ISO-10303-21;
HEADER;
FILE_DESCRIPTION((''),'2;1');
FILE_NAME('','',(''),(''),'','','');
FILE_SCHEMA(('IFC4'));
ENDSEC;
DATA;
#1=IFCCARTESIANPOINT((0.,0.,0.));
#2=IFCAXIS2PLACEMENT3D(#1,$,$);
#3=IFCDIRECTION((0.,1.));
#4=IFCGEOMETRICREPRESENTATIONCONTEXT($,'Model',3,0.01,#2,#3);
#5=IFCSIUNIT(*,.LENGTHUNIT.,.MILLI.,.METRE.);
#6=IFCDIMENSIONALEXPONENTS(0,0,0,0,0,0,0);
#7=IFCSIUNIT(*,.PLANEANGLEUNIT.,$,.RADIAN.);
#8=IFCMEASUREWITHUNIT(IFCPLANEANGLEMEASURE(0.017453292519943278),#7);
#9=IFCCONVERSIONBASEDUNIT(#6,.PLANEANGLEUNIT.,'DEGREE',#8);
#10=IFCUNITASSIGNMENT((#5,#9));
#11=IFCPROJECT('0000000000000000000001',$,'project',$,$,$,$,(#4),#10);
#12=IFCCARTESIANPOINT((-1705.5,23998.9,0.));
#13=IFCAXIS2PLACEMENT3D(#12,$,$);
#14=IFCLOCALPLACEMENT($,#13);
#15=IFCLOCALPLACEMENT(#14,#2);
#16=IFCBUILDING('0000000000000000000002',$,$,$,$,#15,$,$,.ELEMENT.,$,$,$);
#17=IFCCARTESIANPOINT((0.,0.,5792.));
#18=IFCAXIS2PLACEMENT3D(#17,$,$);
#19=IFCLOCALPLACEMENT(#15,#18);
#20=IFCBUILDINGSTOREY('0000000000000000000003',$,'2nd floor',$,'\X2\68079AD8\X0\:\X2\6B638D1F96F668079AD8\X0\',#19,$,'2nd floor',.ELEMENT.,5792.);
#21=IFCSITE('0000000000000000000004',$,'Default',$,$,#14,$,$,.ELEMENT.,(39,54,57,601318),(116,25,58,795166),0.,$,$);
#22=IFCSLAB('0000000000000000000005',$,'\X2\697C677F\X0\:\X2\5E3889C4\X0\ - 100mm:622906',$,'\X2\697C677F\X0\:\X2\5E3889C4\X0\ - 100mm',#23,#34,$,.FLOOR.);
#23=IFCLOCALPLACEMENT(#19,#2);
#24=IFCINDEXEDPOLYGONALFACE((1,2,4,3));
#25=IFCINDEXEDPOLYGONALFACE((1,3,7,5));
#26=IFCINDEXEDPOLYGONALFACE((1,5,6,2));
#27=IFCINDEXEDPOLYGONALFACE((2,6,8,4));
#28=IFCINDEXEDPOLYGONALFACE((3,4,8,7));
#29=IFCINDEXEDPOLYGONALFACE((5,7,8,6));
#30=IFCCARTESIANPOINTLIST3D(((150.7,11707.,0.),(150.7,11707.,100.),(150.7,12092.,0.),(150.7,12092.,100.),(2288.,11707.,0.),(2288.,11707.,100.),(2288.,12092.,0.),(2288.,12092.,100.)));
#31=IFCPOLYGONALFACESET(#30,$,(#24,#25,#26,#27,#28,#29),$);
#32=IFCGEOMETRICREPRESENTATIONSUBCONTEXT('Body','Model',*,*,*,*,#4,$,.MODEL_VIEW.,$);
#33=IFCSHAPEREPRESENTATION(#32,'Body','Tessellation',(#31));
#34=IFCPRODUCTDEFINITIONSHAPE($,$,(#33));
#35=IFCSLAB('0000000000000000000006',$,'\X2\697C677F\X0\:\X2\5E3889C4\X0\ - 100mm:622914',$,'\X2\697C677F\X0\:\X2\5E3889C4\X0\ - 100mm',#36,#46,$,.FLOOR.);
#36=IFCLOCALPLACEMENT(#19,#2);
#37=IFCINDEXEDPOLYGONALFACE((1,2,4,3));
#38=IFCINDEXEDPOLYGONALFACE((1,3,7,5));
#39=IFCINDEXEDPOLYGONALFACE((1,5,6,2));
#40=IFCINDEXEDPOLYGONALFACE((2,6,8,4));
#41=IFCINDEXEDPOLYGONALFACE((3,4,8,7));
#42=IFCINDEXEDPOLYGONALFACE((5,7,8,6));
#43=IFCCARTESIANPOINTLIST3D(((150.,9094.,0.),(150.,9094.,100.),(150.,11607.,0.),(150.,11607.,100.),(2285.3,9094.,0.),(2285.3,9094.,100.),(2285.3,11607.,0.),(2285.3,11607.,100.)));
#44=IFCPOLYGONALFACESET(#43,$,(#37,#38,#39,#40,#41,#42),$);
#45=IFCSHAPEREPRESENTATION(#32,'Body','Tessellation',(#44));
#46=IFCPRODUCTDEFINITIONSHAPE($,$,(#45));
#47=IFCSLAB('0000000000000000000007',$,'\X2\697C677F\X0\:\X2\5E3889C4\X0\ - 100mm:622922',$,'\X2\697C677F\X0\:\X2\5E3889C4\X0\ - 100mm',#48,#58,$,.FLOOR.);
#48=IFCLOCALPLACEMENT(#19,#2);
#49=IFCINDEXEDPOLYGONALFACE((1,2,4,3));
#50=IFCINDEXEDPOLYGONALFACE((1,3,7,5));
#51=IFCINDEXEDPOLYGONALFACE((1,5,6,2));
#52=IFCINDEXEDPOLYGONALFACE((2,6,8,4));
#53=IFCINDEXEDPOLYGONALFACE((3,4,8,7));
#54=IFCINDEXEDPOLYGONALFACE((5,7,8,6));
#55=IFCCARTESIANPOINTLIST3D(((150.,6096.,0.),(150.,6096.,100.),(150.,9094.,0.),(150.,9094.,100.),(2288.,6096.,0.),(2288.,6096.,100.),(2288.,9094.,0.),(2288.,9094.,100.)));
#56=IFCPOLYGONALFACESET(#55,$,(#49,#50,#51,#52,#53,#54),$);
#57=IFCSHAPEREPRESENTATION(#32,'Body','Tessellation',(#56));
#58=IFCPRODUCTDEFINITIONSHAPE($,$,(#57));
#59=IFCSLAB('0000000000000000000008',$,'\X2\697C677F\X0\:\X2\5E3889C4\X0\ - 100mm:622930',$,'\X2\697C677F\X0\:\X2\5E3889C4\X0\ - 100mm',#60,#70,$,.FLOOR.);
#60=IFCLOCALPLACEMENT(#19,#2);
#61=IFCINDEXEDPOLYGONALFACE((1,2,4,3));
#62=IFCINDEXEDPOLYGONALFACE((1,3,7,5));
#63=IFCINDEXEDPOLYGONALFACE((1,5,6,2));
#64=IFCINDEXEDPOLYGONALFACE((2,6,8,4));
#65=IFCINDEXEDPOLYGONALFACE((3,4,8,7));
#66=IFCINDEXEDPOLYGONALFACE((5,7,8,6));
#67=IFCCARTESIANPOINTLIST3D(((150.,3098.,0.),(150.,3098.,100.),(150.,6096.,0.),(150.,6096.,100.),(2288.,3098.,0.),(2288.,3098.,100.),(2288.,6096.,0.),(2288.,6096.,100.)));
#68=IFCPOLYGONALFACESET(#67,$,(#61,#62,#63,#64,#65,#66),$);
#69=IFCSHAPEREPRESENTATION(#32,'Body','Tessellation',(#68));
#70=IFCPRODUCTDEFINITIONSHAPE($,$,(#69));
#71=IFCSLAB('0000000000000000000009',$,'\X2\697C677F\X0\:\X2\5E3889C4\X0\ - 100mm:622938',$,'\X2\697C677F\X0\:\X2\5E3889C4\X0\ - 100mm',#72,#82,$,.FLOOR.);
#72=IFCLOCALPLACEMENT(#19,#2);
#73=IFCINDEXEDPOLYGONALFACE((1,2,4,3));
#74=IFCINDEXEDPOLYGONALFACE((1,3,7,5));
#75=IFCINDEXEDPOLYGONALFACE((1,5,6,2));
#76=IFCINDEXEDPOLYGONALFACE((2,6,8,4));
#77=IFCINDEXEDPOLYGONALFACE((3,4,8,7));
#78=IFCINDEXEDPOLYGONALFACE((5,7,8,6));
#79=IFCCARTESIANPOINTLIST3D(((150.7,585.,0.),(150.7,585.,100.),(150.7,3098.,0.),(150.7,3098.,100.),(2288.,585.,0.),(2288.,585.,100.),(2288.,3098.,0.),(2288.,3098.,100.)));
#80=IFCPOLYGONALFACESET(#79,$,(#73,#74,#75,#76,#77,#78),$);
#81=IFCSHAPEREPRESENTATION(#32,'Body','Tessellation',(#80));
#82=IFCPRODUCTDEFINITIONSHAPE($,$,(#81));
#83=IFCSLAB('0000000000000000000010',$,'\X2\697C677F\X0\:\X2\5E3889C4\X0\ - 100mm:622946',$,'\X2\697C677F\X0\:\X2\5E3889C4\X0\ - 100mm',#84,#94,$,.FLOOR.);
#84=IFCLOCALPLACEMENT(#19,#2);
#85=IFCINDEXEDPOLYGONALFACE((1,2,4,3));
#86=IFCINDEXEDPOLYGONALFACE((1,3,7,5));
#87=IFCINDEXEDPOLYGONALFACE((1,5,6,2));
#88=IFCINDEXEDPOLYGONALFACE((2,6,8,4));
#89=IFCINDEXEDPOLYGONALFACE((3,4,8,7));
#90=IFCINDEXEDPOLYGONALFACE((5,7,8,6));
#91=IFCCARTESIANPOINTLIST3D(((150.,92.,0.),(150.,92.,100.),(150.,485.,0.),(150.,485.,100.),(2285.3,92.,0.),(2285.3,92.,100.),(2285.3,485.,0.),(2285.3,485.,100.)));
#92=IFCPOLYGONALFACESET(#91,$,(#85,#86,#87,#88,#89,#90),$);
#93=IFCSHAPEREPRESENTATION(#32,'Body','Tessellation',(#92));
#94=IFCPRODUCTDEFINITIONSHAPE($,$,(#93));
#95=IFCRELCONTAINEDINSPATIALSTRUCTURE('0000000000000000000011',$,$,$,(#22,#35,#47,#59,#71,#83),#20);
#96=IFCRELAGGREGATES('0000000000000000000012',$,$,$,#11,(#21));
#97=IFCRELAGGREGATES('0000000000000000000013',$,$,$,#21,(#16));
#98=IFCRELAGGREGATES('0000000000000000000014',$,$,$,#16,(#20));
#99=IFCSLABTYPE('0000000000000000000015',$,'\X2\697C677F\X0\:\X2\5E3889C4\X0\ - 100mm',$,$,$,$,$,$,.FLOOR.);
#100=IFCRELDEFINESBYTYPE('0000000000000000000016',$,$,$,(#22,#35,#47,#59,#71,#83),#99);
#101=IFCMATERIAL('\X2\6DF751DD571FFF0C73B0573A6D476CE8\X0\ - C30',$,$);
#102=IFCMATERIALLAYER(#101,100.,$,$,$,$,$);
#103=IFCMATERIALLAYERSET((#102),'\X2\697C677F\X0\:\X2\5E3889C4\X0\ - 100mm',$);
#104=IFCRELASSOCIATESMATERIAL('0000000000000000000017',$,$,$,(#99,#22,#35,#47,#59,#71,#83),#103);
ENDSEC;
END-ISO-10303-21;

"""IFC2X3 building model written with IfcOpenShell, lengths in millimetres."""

from ifc_helpers import new_model, entity, si_unit, converted_unit, direction, frame, frame_2d, origin, origin_2d_with_axis, place, context, subcontext, project, spatial, rectangle, extrude, material, layer, layer_set, layer_usage, type_object, element, save


model = new_model("IFC2X3")

# Units and contexts
model_context = context("Model", 3, precision=0.01, world=origin(), true_north=direction((0.0, 1.0)))
body_context = subcontext(model_context, "Body", "Model", "MODEL_VIEW")
ifc_project = project(units=[si_unit("LENGTHUNIT", "METRE", prefix="MILLI"), converted_unit("PLANEANGLEUNIT", "DEGREE", entity("IfcPlaneAngleMeasure", 0.017453292519943278), si_unit("PLANEANGLEUNIT", "RADIAN"), dimensions=[0, 0, 0, 0, 0, 0, 0])], contexts=[model_context])

# Site, building, storey
site_placement = place(None, frame((-1705.5, 23998.9, 0.0)))
site = spatial("IfcSite", under=ifc_project, at=site_placement, Name="Default", CompositionType="ELEMENT", RefLatitude=(39, 54, 57, 601318), RefLongitude=(116, 25, 58, 795166), RefElevation=0.0)
building_placement = place(site_placement, origin())
building = spatial("IfcBuilding", under=site, at=building_placement, CompositionType="ELEMENT")
storey_placement = place(building_placement, frame((0.0, 0.0, 5792.0)))
storey = spatial("IfcBuildingStorey", under=building, at=storey_placement, Name="2nd floor", ObjectType="标高:正负零标高", LongName="2nd floor", CompositionType="ELEMENT", Elevation=5792.0)

# Slabs
ifc_material_1 = material(Name="混凝土，现场浇注 - C30")
ifc_layer_1 = layer(ifc_material_1, 100.0)
ifc_layer_set_1 = layer_set([ifc_layer_1], Name="楼板:常规 - 100mm")
ifc_layer_usage_1 = layer_usage(ifc_layer_set_1, "AXIS3", "POSITIVE", 0.0)
slab_type = type_object("IfcSlabType", Name="楼板:常规 - 100mm", PredefinedType="FLOOR", material=ifc_layer_set_1)
slab_1_placement = place(storey_placement, origin())
element("IfcSlab", 1, at=slab_1_placement, inside=storey, type_object=slab_type, material=ifc_layer_usage_1, Name="楼板:常规 - 100mm:622906", ObjectType="楼板:常规 - 100mm", PredefinedType="FLOOR", context=body_context, shape_type="SweptSolid", body=[
    extrude(rectangle(XDim=385.0, YDim=2137.3, at=origin_2d_with_axis()), frame((1219.3, 11899.5, 100.0), z_axis=(0.0, 0.0, -1.0), x_axis=(0.0, 1.0, 0.0)), (0.0, 0.0, 1.0), 100.0),
])
ifc_layer_usage_2 = layer_usage(ifc_layer_set_1, "AXIS3", "POSITIVE", 0.0)
slab_2_placement = place(storey_placement, origin())
element("IfcSlab", 2, at=slab_2_placement, inside=storey, type_object=slab_type, material=ifc_layer_usage_2, Name="楼板:常规 - 100mm:622914", ObjectType="楼板:常规 - 100mm", PredefinedType="FLOOR", context=body_context, shape_type="SweptSolid", body=[
    extrude(rectangle(XDim=2513.0, YDim=2135.3, at=frame_2d((0.0, 0.0), x_axis=(1.0, 0.0))), frame((1217.6, 10350.5, 100.0), z_axis=(0.0, 0.0, -1.0), x_axis=(0.0, 1.0, 0.0)), (0.0, 0.0, 1.0), 100.0),
])
ifc_layer_usage_3 = layer_usage(ifc_layer_set_1, "AXIS3", "POSITIVE", 0.0)
slab_3_placement = place(storey_placement, origin())
element("IfcSlab", 3, at=slab_3_placement, inside=storey, type_object=slab_type, material=ifc_layer_usage_3, Name="楼板:常规 - 100mm:622922", ObjectType="楼板:常规 - 100mm", PredefinedType="FLOOR", context=body_context, shape_type="SweptSolid", body=[
    extrude(rectangle(XDim=2998.0, YDim=2138.0, at=origin_2d_with_axis()), frame((1219.0, 7595.0, 100.0), z_axis=(0.0, 0.0, -1.0), x_axis=(0.0, 1.0, 0.0)), (0.0, 0.0, 1.0), 100.0),
])
ifc_layer_usage_4 = layer_usage(ifc_layer_set_1, "AXIS3", "POSITIVE", 0.0)
slab_4_placement = place(storey_placement, origin())
element("IfcSlab", 4, at=slab_4_placement, inside=storey, type_object=slab_type, material=ifc_layer_usage_4, Name="楼板:常规 - 100mm:622930", ObjectType="楼板:常规 - 100mm", PredefinedType="FLOOR", context=body_context, shape_type="SweptSolid", body=[
    extrude(rectangle(XDim=2998.0, YDim=2138.0, at=frame_2d((0.0, 0.0), x_axis=(1.0, 0.0))), frame((1219.0, 4597.0, 100.0), z_axis=(0.0, 0.0, -1.0), x_axis=(0.0, 1.0, 0.0)), (0.0, 0.0, 1.0), 100.0),
])
ifc_layer_usage_5 = layer_usage(ifc_layer_set_1, "AXIS3", "POSITIVE", 0.0)
slab_5_placement = place(storey_placement, origin())
element("IfcSlab", 5, at=slab_5_placement, inside=storey, type_object=slab_type, material=ifc_layer_usage_5, Name="楼板:常规 - 100mm:622938", ObjectType="楼板:常规 - 100mm", PredefinedType="FLOOR", context=body_context, shape_type="SweptSolid", body=[
    extrude(rectangle(XDim=2513.0, YDim=2137.3, at=origin_2d_with_axis()), frame((1219.3, 1841.5, 100.0), z_axis=(0.0, 0.0, -1.0), x_axis=(0.0, 1.0, 0.0)), (0.0, 0.0, 1.0), 100.0),
])
ifc_layer_usage_6 = layer_usage(ifc_layer_set_1, "AXIS3", "POSITIVE", 0.0)
slab_6_placement = place(storey_placement, origin())
element("IfcSlab", 6, at=slab_6_placement, inside=storey, type_object=slab_type, material=ifc_layer_usage_6, Name="楼板:常规 - 100mm:622946", ObjectType="楼板:常规 - 100mm", PredefinedType="FLOOR", context=body_context, shape_type="SweptSolid", body=[
    extrude(rectangle(XDim=393.0, YDim=2135.3, at=frame_2d((0.0, 0.0), x_axis=(1.0, 0.0))), frame((1217.7, 288.5, 100.0), z_axis=(0.0, 0.0, -1.0), x_axis=(0.0, 1.0, 0.0)), (0.0, 0.0, 1.0), 100.0),
])

save(model, "model.ifc")
